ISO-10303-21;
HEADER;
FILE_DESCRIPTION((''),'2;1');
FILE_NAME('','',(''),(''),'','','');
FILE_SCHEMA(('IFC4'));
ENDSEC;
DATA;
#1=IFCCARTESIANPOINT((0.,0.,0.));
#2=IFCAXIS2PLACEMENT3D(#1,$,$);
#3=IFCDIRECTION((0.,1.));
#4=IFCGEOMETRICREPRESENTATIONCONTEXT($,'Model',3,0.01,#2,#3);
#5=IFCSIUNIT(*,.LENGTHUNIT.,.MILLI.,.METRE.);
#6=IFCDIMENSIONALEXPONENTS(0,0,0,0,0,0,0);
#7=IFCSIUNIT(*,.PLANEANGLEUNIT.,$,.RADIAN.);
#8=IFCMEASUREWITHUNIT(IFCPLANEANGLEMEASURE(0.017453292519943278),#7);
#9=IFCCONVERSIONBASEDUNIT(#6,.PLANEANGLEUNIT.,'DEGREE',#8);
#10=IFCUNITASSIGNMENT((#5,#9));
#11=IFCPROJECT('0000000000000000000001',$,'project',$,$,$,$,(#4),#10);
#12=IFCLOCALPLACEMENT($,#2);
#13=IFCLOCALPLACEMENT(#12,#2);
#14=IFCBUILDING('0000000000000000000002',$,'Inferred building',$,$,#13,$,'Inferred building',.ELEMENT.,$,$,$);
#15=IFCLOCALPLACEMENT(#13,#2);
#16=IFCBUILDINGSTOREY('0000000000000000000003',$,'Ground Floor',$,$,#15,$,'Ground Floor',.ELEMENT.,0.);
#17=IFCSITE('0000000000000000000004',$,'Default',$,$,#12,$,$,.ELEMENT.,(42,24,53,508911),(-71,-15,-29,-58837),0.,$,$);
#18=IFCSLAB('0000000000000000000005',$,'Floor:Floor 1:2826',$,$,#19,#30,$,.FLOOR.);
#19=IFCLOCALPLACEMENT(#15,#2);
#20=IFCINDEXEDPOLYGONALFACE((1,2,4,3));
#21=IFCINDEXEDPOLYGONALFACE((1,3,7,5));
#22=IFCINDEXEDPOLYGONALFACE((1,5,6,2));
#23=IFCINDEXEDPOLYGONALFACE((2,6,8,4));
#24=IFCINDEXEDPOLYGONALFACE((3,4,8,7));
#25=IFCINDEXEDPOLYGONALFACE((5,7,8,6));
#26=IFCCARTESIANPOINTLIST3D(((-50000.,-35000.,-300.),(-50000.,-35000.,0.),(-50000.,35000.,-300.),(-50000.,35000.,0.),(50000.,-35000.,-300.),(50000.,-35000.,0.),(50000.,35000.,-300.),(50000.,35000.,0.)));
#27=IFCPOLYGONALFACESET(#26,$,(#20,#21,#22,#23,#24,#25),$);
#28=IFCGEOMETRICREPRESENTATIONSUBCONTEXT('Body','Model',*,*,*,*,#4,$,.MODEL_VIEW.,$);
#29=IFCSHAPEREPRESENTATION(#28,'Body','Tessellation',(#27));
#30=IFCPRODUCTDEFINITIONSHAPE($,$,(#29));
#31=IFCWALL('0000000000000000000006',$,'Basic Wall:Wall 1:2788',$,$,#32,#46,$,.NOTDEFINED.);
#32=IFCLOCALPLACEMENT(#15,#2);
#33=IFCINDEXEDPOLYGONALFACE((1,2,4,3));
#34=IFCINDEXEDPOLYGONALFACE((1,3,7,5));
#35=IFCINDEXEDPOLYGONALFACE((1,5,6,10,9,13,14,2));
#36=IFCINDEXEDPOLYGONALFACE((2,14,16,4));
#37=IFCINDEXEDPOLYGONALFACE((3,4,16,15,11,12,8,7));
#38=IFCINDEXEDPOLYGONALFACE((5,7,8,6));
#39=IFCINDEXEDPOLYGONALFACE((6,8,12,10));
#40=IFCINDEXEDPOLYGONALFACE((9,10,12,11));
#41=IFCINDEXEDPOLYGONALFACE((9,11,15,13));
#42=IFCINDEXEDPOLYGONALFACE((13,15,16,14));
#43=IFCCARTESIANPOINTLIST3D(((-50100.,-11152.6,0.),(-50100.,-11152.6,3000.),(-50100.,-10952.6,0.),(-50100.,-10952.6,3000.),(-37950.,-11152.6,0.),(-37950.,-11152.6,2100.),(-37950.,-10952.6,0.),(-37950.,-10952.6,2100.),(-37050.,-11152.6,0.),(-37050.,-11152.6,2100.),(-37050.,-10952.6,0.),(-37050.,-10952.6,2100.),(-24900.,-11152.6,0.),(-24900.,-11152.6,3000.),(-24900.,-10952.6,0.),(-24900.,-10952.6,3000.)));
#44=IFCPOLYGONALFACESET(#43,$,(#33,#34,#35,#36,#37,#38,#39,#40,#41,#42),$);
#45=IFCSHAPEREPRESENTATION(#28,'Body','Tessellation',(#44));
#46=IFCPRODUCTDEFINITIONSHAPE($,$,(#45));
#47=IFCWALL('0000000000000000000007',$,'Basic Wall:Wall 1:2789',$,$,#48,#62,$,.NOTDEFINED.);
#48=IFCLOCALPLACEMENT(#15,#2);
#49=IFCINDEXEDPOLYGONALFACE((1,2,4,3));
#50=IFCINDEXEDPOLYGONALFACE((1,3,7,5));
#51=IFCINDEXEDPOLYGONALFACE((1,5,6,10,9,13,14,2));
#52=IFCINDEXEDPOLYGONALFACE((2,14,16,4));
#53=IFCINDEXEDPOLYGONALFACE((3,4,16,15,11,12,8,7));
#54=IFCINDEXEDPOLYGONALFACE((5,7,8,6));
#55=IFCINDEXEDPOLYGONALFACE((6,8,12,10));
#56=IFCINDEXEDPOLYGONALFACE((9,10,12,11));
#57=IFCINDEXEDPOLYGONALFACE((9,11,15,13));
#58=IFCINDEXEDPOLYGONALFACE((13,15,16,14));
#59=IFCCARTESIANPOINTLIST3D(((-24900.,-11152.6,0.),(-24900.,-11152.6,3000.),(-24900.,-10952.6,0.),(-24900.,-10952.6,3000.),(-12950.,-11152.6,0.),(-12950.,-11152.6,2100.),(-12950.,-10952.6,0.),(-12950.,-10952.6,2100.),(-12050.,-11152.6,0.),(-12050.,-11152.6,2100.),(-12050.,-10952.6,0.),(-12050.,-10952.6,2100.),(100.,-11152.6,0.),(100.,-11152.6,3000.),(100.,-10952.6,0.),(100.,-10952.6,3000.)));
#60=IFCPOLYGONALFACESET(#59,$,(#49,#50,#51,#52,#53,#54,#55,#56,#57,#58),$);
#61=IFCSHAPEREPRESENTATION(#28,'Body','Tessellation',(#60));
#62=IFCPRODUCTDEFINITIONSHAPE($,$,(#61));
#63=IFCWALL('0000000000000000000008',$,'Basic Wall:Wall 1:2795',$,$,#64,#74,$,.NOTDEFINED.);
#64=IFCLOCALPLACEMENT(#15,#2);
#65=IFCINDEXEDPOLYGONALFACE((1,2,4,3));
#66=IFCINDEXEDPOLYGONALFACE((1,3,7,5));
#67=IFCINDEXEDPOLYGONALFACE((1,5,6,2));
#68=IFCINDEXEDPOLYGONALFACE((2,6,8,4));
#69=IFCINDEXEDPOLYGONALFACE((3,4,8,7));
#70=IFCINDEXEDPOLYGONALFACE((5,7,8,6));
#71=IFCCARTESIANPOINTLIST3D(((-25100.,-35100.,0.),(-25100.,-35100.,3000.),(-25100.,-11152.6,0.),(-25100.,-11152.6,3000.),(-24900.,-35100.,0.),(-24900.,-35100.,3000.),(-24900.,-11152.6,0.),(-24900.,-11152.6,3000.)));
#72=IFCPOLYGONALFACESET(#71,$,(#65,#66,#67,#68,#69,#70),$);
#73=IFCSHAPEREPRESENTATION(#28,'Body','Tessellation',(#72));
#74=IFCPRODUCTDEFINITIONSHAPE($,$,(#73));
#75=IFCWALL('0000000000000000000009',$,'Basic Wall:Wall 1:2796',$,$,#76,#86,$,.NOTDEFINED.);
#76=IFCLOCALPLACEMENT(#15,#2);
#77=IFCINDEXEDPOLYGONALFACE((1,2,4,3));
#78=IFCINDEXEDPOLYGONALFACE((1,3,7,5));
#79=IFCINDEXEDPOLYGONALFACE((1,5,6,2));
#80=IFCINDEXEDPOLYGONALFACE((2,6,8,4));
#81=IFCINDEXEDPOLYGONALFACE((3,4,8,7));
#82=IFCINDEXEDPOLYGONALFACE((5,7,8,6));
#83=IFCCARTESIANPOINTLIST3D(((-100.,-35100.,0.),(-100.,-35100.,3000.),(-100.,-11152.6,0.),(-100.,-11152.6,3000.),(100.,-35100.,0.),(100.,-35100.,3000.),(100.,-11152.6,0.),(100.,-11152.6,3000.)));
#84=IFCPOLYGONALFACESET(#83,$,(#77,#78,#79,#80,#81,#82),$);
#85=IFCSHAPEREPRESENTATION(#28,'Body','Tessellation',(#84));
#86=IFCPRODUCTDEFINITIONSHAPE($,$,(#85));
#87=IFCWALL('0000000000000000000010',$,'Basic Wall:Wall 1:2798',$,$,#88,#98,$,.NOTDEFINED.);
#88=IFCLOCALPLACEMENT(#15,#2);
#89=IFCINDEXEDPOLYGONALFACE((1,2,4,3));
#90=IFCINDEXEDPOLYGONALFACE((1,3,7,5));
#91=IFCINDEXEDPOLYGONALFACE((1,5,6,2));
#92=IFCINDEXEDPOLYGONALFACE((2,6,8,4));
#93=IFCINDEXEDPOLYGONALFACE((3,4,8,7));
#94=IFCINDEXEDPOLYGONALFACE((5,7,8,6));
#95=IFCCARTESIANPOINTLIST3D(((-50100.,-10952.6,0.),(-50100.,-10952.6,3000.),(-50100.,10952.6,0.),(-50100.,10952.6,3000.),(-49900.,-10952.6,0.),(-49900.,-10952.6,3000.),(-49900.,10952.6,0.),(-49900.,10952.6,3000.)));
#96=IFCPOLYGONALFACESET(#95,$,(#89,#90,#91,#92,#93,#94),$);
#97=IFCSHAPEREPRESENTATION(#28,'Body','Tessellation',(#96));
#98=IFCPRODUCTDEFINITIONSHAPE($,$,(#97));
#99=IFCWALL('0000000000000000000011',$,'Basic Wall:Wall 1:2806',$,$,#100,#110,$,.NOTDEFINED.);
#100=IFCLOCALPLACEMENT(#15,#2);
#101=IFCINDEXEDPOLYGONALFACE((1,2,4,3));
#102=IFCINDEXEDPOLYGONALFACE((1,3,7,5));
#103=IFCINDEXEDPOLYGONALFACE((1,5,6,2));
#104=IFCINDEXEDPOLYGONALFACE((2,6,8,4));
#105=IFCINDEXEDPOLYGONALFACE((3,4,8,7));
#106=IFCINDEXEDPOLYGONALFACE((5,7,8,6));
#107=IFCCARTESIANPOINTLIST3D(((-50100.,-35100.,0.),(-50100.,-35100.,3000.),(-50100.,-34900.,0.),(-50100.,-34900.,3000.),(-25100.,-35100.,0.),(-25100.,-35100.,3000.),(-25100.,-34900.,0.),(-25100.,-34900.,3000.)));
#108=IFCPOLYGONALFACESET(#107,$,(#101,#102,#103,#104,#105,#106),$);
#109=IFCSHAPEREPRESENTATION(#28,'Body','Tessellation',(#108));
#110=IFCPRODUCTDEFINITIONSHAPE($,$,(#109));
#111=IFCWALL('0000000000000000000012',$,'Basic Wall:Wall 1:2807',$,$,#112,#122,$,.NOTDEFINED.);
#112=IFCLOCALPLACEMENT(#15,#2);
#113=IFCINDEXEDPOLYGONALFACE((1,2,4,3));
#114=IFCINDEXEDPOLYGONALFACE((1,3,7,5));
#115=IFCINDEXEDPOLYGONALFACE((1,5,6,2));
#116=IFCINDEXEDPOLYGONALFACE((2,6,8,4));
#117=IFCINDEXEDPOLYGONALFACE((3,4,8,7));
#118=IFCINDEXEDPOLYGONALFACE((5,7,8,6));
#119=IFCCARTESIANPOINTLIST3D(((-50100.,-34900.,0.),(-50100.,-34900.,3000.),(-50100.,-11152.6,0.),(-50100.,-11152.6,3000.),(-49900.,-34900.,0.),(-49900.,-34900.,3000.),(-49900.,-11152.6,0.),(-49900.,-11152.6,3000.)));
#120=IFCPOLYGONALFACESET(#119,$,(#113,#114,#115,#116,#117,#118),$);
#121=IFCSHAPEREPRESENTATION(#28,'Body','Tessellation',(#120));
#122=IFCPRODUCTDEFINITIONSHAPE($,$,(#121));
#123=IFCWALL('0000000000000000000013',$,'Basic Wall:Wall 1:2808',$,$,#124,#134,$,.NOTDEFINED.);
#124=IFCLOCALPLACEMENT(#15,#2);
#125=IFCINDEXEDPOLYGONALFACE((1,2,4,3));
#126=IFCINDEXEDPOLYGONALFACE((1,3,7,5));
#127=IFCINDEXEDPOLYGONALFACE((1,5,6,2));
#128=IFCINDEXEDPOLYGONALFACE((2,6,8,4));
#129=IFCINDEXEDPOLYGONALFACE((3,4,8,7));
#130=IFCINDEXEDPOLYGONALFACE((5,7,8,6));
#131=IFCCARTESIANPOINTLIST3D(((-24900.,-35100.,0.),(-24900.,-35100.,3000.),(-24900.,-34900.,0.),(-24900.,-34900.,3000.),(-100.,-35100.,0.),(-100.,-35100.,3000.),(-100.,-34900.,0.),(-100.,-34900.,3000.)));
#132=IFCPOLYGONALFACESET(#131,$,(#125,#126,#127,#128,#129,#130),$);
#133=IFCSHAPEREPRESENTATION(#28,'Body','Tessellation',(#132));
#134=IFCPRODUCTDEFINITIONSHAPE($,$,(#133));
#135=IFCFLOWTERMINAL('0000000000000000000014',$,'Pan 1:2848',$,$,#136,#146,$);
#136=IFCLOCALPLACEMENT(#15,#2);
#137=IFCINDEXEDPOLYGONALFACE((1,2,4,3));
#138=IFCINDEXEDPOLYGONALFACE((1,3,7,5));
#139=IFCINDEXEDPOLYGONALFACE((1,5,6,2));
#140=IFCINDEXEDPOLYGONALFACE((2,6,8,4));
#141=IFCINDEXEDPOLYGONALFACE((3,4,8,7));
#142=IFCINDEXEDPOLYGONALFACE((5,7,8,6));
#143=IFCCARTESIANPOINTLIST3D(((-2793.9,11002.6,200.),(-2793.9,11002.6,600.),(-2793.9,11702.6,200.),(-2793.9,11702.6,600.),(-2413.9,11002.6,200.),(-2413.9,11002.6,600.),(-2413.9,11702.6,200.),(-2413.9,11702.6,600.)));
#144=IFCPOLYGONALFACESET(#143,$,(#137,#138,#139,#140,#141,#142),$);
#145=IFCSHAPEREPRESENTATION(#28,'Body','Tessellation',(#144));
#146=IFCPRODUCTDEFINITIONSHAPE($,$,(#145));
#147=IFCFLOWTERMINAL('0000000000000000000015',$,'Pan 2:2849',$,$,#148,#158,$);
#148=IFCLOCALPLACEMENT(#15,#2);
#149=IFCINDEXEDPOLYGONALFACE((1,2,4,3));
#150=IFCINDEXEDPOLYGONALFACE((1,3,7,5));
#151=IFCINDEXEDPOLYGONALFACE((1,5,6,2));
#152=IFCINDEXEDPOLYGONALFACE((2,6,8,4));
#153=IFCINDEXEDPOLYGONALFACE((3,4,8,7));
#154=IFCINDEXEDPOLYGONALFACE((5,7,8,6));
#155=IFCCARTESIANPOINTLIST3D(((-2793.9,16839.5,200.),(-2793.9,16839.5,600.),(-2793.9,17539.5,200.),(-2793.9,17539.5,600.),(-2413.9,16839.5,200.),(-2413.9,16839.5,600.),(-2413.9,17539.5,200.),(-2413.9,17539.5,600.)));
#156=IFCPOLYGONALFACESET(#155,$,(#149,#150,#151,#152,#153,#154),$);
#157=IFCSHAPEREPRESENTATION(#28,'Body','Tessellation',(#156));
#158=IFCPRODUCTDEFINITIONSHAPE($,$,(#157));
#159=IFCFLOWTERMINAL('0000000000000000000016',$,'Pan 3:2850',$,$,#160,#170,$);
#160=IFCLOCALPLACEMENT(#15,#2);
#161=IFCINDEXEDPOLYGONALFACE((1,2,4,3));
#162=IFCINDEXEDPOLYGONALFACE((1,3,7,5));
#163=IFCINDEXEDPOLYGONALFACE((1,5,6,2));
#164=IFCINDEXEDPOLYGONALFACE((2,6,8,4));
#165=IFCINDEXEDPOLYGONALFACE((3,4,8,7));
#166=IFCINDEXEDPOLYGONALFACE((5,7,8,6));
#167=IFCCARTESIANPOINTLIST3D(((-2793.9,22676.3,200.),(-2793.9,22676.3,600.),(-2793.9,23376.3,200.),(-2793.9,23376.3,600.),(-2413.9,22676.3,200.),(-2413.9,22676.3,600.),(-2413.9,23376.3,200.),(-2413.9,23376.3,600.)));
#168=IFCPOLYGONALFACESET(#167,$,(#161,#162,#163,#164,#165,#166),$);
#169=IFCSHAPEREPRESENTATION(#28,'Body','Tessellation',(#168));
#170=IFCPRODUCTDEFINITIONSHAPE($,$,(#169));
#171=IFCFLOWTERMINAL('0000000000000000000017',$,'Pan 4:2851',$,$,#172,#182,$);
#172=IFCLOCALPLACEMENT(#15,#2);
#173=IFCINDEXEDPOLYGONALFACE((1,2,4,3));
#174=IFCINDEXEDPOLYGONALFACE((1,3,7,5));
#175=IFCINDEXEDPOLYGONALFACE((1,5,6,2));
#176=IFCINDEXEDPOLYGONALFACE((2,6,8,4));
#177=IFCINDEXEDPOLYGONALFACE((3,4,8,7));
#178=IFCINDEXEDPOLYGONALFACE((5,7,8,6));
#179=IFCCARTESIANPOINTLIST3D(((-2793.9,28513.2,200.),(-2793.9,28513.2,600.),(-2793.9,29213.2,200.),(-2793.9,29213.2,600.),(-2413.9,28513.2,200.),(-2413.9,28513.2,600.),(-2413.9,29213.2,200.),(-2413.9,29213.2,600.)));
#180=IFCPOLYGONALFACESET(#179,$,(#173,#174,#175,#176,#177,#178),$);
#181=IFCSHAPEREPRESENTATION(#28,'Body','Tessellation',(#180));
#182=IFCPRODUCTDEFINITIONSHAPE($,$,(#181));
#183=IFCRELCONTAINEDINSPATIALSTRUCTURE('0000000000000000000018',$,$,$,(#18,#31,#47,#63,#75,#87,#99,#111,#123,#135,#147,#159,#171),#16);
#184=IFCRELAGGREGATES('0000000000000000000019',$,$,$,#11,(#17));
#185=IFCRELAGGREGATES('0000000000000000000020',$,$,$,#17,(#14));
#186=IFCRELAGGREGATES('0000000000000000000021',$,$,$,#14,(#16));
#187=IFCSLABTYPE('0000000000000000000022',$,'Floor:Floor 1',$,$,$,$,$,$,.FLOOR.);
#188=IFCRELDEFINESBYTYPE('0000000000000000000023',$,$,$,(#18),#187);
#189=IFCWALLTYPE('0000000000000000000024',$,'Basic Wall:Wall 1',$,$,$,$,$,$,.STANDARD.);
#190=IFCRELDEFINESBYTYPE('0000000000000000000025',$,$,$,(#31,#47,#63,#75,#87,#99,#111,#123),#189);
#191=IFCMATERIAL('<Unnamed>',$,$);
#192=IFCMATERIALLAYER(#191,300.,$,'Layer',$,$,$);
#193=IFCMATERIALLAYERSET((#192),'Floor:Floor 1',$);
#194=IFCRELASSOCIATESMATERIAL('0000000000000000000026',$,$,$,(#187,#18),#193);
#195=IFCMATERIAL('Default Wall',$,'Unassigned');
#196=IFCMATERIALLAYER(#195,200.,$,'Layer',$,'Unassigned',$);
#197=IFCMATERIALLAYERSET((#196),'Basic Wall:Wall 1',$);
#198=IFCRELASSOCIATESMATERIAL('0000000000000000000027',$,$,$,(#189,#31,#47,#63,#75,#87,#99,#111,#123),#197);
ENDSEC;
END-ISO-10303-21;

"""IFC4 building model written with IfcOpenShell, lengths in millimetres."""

from ifc_helpers import new_model, entity, si_unit, converted_unit, direction, frame, frame_2d, origin, origin_2d_with_axis, place, context, subcontext, project, spatial, rectangle, extrude, material, layer, layer_set, layer_usage, type_object, element, save


model = new_model("IFC4")

# Units and contexts
model_context = context("Model", 3, precision=0.01, world=origin(), true_north=direction((0.0, 1.0)))
body_context = subcontext(model_context, "Body", "Model", "MODEL_VIEW")
ifc_project = project(units=[si_unit("LENGTHUNIT", "METRE", prefix="MILLI"), converted_unit("PLANEANGLEUNIT", "DEGREE", entity("IfcPlaneAngleMeasure", 0.017453292519943278), si_unit("PLANEANGLEUNIT", "RADIAN"), dimensions=[0, 0, 0, 0, 0, 0, 0])], contexts=[model_context])

# Site, building, storey
site_placement = place(None, origin())
site = spatial("IfcSite", under=ifc_project, at=site_placement, Name="Default", CompositionType="ELEMENT", RefLatitude=(42, 24, 53, 508911), RefLongitude=(-71, -15, -29, -58837), RefElevation=0.0)
building_placement = place(site_placement, origin())
building = spatial("IfcBuilding", under=site, at=building_placement, Name="Inferred building", LongName="Inferred building", CompositionType="ELEMENT")
storey_placement = place(building_placement, origin())
storey = spatial("IfcBuildingStorey", under=building, at=storey_placement, Name="Ground Floor", LongName="Ground Floor", CompositionType="ELEMENT", Elevation=0.0)

# Slab
ifc_material_1 = material(Name="<Unnamed>")
ifc_layer_1 = layer(ifc_material_1, 300.0, Name="Layer")
ifc_layer_set_1 = layer_set([ifc_layer_1], Name="Floor:Floor 1")
ifc_layer_usage_1 = layer_usage(ifc_layer_set_1, "AXIS3", "POSITIVE", 0.0)
slab_type = type_object("IfcSlabType", Name="Floor:Floor 1", PredefinedType="FLOOR", material=ifc_layer_set_1)
slab_placement = place(storey_placement, origin())
element("IfcSlab", 1, at=slab_placement, inside=storey, type_object=slab_type, material=ifc_layer_usage_1, Name="Floor:Floor 1:2826", PredefinedType="FLOOR", context=body_context, shape_type="SweptSolid", body=[
    extrude(rectangle(XDim=70000.0, YDim=100000.0, at=origin_2d_with_axis()), frame((0.0, 0.0, 0.0), z_axis=(0.0, 0.0, -1.0), x_axis=(0.0, 1.0, 0.0)), (0.0, 0.0, 1.0), 300.0),
])

# Walls, openings
ifc_material_2 = material(Name="Default Wall", Category="Unassigned")
ifc_layer_2 = layer(ifc_material_2, 200.0, Name="Layer", Category="Unassigned")
ifc_layer_set_2 = layer_set([ifc_layer_2], Name="Basic Wall:Wall 1")
ifc_layer_usage_2 = layer_usage(ifc_layer_set_2, "AXIS2", "NEGATIVE", 100.0)
wall_type = type_object("IfcWallType", Name="Basic Wall:Wall 1", PredefinedType="STANDARD", material=ifc_layer_set_2)
wall_1_placement = place(storey_placement, frame((-50100.0, -11052.6, 0.0)))
wall_1 = element("IfcWall", 2, at=wall_1_placement, inside=storey, type_object=wall_type, material=ifc_layer_usage_2, Name="Basic Wall:Wall 1:2788", PredefinedType="NOTDEFINED", context=body_context, shape_type="SweptSolid", body=[
    extrude(rectangle(XDim=25200.0, YDim=200.0, at=frame_2d((12600.0, 0.0), x_axis=(-1.0, 0.0))), origin(), (0.0, 0.0, 1.0), 3000.0),
])
opening_1_placement = place(wall_1_placement, origin())
element("IfcOpeningElement", 3, at=opening_1_placement, cuts=wall_1, PredefinedType="OPENING", context=body_context, shape_type="SweptSolid", body=[
    extrude(rectangle(XDim=2100.0, YDim=900.0, at=frame_2d((0.0, 0.0), x_axis=(1.0, 0.0))), frame((12600.0, -100.0, 1050.0), z_axis=(0.0, 1.0, 0.0), x_axis=(0.0, 0.0, -1.0)), (0.0, 0.0, 1.0), 200.0),
])
ifc_layer_usage_3 = layer_usage(ifc_layer_set_2, "AXIS2", "NEGATIVE", 100.0)
wall_2_placement = place(storey_placement, frame((-24900.0, -11052.6, 0.0)))
wall_2 = element("IfcWall", 4, at=wall_2_placement, inside=storey, type_object=wall_type, material=ifc_layer_usage_3, Name="Basic Wall:Wall 1:2789", PredefinedType="NOTDEFINED", context=body_context, shape_type="SweptSolid", body=[
    extrude(rectangle(XDim=25000.0, YDim=200.0, at=frame_2d((12500.0, 0.0), x_axis=(-1.0, 0.0))), origin(), (0.0, 0.0, 1.0), 3000.0),
])
opening_2_placement = place(wall_2_placement, origin())
element("IfcOpeningElement", 5, at=opening_2_placement, cuts=wall_2, PredefinedType="OPENING", context=body_context, shape_type="SweptSolid", body=[
    extrude(rectangle(XDim=2100.0, YDim=900.0, at=origin_2d_with_axis()), frame((12400.0, -100.0, 1050.0), z_axis=(0.0, 1.0, 0.0), x_axis=(0.0, 0.0, -1.0)), (0.0, 0.0, 1.0), 200.0),
])

# Walls
ifc_layer_usage_4 = layer_usage(ifc_layer_set_2, "AXIS2", "NEGATIVE", 100.0)
wall_3_placement = place(storey_placement, frame((-25000.0, -35100.0, 0.0), z_axis=(0.0, 0.0, 1.0), x_axis=(0.0, 1.0, 0.0)))
element("IfcWall", 6, at=wall_3_placement, inside=storey, type_object=wall_type, material=ifc_layer_usage_4, Name="Basic Wall:Wall 1:2795", PredefinedType="NOTDEFINED", context=body_context, shape_type="SweptSolid", body=[
    extrude(rectangle(XDim=23947.4, YDim=200.0, at=frame_2d((11973.7, 0.0), x_axis=(-1.0, 0.0))), origin(), (0.0, 0.0, 1.0), 3000.0),
])
ifc_layer_usage_5 = layer_usage(ifc_layer_set_2, "AXIS2", "NEGATIVE", 100.0)
wall_4_placement = place(storey_placement, frame((0.0, -35100.0, 0.0), z_axis=(0.0, 0.0, 1.0), x_axis=(0.0, 1.0, 0.0)))
element("IfcWall", 7, at=wall_4_placement, inside=storey, type_object=wall_type, material=ifc_layer_usage_5, Name="Basic Wall:Wall 1:2796", PredefinedType="NOTDEFINED", context=body_context, shape_type="SweptSolid", body=[
    extrude(rectangle(XDim=23947.4, YDim=200.0, at=frame_2d((11973.7, 0.0), x_axis=(-1.0, 0.0))), origin(), (0.0, 0.0, 1.0), 3000.0),
])
ifc_layer_usage_6 = layer_usage(ifc_layer_set_2, "AXIS2", "NEGATIVE", 100.0)
wall_5_placement = place(storey_placement, frame((-50000.0, -10952.6, 0.0), z_axis=(0.0, 0.0, 1.0), x_axis=(0.0, 1.0, 0.0)))
element("IfcWall", 8, at=wall_5_placement, inside=storey, type_object=wall_type, material=ifc_layer_usage_6, Name="Basic Wall:Wall 1:2798", PredefinedType="NOTDEFINED", context=body_context, shape_type="SweptSolid", body=[
    extrude(rectangle(XDim=21905.3, YDim=200.0, at=frame_2d((10952.6, 0.0), x_axis=(-1.0, 0.0))), origin(), (0.0, 0.0, 1.0), 3000.0),
])
ifc_layer_usage_7 = layer_usage(ifc_layer_set_2, "AXIS2", "NEGATIVE", 100.0)
wall_6_placement = place(storey_placement, frame((-50100.0, -35000.0, 0.0)))
element("IfcWall", 9, at=wall_6_placement, inside=storey, type_object=wall_type, material=ifc_layer_usage_7, Name="Basic Wall:Wall 1:2806", PredefinedType="NOTDEFINED", context=body_context, shape_type="SweptSolid", body=[
    extrude(rectangle(XDim=25000.0, YDim=200.0, at=frame_2d((12500.0, 0.0), x_axis=(-1.0, 0.0))), origin(), (0.0, 0.0, 1.0), 3000.0),
])
ifc_layer_usage_8 = layer_usage(ifc_layer_set_2, "AXIS2", "NEGATIVE", 100.0)
wall_7_placement = place(storey_placement, frame((-50000.0, -34900.0, 0.0), z_axis=(0.0, 0.0, 1.0), x_axis=(0.0, 1.0, 0.0)))
element("IfcWall", 10, at=wall_7_placement, inside=storey, type_object=wall_type, material=ifc_layer_usage_8, Name="Basic Wall:Wall 1:2807", PredefinedType="NOTDEFINED", context=body_context, shape_type="SweptSolid", body=[
    extrude(rectangle(XDim=23747.4, YDim=200.0, at=frame_2d((11873.7, 0.0), x_axis=(-1.0, 0.0))), origin(), (0.0, 0.0, 1.0), 3000.0),
])
ifc_layer_usage_9 = layer_usage(ifc_layer_set_2, "AXIS2", "NEGATIVE", 100.0)
wall_8_placement = place(storey_placement, frame((-24900.0, -35000.0, 0.0)))
element("IfcWall", 11, at=wall_8_placement, inside=storey, type_object=wall_type, material=ifc_layer_usage_9, Name="Basic Wall:Wall 1:2808", PredefinedType="NOTDEFINED", context=body_context, shape_type="SweptSolid", body=[
    extrude(rectangle(XDim=24800.0, YDim=200.0, at=frame_2d((12400.0, 0.0), x_axis=(-1.0, 0.0))), origin(), (0.0, 0.0, 1.0), 3000.0),
])

# Flow terminals
flow_terminal_1_placement = place(storey_placement, origin())
element("IfcFlowTerminal", 12, at=flow_terminal_1_placement, inside=storey, Name="Pan 1:2848", context=body_context, shape_type="SweptSolid", body=[
    extrude(rectangle(XDim=700.0, YDim=380.0, at=origin_2d_with_axis()), frame((-2603.9, 11352.6, 200.0), z_axis=(0.0, 0.0, 1.0), x_axis=(0.0, 1.0, 0.0)), (0.0, 0.0, 1.0), 400.0),
])
flow_terminal_2_placement = place(storey_placement, origin())
element("IfcFlowTerminal", 13, at=flow_terminal_2_placement, inside=storey, Name="Pan 2:2849", context=body_context, shape_type="SweptSolid", body=[
    extrude(rectangle(XDim=700.0, YDim=380.0, at=origin_2d_with_axis()), frame((-2603.9, 17189.5, 200.0), z_axis=(0.0, 0.0, 1.0), x_axis=(0.0, 1.0, 0.0)), (0.0, 0.0, 1.0), 400.0),
])
flow_terminal_3_placement = place(storey_placement, origin())
element("IfcFlowTerminal", 14, at=flow_terminal_3_placement, inside=storey, Name="Pan 3:2850", context=body_context, shape_type="SweptSolid", body=[
    extrude(rectangle(XDim=700.0, YDim=380.0, at=origin_2d_with_axis()), frame((-2603.9, 23026.3, 200.0), z_axis=(0.0, 0.0, 1.0), x_axis=(0.0, 1.0, 0.0)), (0.0, 0.0, 1.0), 400.0),
])
flow_terminal_4_placement = place(storey_placement, origin())
element("IfcFlowTerminal", 15, at=flow_terminal_4_placement, inside=storey, Name="Pan 4:2851", context=body_context, shape_type="SweptSolid", body=[
    extrude(rectangle(XDim=700.0, YDim=380.0, at=origin_2d_with_axis()), frame((-2603.9, 28863.2, 200.0), z_axis=(0.0, 0.0, 1.0), x_axis=(0.0, 1.0, 0.0)), (0.0, 0.0, 1.0), 400.0),
])

save(model, "model.ifc")
